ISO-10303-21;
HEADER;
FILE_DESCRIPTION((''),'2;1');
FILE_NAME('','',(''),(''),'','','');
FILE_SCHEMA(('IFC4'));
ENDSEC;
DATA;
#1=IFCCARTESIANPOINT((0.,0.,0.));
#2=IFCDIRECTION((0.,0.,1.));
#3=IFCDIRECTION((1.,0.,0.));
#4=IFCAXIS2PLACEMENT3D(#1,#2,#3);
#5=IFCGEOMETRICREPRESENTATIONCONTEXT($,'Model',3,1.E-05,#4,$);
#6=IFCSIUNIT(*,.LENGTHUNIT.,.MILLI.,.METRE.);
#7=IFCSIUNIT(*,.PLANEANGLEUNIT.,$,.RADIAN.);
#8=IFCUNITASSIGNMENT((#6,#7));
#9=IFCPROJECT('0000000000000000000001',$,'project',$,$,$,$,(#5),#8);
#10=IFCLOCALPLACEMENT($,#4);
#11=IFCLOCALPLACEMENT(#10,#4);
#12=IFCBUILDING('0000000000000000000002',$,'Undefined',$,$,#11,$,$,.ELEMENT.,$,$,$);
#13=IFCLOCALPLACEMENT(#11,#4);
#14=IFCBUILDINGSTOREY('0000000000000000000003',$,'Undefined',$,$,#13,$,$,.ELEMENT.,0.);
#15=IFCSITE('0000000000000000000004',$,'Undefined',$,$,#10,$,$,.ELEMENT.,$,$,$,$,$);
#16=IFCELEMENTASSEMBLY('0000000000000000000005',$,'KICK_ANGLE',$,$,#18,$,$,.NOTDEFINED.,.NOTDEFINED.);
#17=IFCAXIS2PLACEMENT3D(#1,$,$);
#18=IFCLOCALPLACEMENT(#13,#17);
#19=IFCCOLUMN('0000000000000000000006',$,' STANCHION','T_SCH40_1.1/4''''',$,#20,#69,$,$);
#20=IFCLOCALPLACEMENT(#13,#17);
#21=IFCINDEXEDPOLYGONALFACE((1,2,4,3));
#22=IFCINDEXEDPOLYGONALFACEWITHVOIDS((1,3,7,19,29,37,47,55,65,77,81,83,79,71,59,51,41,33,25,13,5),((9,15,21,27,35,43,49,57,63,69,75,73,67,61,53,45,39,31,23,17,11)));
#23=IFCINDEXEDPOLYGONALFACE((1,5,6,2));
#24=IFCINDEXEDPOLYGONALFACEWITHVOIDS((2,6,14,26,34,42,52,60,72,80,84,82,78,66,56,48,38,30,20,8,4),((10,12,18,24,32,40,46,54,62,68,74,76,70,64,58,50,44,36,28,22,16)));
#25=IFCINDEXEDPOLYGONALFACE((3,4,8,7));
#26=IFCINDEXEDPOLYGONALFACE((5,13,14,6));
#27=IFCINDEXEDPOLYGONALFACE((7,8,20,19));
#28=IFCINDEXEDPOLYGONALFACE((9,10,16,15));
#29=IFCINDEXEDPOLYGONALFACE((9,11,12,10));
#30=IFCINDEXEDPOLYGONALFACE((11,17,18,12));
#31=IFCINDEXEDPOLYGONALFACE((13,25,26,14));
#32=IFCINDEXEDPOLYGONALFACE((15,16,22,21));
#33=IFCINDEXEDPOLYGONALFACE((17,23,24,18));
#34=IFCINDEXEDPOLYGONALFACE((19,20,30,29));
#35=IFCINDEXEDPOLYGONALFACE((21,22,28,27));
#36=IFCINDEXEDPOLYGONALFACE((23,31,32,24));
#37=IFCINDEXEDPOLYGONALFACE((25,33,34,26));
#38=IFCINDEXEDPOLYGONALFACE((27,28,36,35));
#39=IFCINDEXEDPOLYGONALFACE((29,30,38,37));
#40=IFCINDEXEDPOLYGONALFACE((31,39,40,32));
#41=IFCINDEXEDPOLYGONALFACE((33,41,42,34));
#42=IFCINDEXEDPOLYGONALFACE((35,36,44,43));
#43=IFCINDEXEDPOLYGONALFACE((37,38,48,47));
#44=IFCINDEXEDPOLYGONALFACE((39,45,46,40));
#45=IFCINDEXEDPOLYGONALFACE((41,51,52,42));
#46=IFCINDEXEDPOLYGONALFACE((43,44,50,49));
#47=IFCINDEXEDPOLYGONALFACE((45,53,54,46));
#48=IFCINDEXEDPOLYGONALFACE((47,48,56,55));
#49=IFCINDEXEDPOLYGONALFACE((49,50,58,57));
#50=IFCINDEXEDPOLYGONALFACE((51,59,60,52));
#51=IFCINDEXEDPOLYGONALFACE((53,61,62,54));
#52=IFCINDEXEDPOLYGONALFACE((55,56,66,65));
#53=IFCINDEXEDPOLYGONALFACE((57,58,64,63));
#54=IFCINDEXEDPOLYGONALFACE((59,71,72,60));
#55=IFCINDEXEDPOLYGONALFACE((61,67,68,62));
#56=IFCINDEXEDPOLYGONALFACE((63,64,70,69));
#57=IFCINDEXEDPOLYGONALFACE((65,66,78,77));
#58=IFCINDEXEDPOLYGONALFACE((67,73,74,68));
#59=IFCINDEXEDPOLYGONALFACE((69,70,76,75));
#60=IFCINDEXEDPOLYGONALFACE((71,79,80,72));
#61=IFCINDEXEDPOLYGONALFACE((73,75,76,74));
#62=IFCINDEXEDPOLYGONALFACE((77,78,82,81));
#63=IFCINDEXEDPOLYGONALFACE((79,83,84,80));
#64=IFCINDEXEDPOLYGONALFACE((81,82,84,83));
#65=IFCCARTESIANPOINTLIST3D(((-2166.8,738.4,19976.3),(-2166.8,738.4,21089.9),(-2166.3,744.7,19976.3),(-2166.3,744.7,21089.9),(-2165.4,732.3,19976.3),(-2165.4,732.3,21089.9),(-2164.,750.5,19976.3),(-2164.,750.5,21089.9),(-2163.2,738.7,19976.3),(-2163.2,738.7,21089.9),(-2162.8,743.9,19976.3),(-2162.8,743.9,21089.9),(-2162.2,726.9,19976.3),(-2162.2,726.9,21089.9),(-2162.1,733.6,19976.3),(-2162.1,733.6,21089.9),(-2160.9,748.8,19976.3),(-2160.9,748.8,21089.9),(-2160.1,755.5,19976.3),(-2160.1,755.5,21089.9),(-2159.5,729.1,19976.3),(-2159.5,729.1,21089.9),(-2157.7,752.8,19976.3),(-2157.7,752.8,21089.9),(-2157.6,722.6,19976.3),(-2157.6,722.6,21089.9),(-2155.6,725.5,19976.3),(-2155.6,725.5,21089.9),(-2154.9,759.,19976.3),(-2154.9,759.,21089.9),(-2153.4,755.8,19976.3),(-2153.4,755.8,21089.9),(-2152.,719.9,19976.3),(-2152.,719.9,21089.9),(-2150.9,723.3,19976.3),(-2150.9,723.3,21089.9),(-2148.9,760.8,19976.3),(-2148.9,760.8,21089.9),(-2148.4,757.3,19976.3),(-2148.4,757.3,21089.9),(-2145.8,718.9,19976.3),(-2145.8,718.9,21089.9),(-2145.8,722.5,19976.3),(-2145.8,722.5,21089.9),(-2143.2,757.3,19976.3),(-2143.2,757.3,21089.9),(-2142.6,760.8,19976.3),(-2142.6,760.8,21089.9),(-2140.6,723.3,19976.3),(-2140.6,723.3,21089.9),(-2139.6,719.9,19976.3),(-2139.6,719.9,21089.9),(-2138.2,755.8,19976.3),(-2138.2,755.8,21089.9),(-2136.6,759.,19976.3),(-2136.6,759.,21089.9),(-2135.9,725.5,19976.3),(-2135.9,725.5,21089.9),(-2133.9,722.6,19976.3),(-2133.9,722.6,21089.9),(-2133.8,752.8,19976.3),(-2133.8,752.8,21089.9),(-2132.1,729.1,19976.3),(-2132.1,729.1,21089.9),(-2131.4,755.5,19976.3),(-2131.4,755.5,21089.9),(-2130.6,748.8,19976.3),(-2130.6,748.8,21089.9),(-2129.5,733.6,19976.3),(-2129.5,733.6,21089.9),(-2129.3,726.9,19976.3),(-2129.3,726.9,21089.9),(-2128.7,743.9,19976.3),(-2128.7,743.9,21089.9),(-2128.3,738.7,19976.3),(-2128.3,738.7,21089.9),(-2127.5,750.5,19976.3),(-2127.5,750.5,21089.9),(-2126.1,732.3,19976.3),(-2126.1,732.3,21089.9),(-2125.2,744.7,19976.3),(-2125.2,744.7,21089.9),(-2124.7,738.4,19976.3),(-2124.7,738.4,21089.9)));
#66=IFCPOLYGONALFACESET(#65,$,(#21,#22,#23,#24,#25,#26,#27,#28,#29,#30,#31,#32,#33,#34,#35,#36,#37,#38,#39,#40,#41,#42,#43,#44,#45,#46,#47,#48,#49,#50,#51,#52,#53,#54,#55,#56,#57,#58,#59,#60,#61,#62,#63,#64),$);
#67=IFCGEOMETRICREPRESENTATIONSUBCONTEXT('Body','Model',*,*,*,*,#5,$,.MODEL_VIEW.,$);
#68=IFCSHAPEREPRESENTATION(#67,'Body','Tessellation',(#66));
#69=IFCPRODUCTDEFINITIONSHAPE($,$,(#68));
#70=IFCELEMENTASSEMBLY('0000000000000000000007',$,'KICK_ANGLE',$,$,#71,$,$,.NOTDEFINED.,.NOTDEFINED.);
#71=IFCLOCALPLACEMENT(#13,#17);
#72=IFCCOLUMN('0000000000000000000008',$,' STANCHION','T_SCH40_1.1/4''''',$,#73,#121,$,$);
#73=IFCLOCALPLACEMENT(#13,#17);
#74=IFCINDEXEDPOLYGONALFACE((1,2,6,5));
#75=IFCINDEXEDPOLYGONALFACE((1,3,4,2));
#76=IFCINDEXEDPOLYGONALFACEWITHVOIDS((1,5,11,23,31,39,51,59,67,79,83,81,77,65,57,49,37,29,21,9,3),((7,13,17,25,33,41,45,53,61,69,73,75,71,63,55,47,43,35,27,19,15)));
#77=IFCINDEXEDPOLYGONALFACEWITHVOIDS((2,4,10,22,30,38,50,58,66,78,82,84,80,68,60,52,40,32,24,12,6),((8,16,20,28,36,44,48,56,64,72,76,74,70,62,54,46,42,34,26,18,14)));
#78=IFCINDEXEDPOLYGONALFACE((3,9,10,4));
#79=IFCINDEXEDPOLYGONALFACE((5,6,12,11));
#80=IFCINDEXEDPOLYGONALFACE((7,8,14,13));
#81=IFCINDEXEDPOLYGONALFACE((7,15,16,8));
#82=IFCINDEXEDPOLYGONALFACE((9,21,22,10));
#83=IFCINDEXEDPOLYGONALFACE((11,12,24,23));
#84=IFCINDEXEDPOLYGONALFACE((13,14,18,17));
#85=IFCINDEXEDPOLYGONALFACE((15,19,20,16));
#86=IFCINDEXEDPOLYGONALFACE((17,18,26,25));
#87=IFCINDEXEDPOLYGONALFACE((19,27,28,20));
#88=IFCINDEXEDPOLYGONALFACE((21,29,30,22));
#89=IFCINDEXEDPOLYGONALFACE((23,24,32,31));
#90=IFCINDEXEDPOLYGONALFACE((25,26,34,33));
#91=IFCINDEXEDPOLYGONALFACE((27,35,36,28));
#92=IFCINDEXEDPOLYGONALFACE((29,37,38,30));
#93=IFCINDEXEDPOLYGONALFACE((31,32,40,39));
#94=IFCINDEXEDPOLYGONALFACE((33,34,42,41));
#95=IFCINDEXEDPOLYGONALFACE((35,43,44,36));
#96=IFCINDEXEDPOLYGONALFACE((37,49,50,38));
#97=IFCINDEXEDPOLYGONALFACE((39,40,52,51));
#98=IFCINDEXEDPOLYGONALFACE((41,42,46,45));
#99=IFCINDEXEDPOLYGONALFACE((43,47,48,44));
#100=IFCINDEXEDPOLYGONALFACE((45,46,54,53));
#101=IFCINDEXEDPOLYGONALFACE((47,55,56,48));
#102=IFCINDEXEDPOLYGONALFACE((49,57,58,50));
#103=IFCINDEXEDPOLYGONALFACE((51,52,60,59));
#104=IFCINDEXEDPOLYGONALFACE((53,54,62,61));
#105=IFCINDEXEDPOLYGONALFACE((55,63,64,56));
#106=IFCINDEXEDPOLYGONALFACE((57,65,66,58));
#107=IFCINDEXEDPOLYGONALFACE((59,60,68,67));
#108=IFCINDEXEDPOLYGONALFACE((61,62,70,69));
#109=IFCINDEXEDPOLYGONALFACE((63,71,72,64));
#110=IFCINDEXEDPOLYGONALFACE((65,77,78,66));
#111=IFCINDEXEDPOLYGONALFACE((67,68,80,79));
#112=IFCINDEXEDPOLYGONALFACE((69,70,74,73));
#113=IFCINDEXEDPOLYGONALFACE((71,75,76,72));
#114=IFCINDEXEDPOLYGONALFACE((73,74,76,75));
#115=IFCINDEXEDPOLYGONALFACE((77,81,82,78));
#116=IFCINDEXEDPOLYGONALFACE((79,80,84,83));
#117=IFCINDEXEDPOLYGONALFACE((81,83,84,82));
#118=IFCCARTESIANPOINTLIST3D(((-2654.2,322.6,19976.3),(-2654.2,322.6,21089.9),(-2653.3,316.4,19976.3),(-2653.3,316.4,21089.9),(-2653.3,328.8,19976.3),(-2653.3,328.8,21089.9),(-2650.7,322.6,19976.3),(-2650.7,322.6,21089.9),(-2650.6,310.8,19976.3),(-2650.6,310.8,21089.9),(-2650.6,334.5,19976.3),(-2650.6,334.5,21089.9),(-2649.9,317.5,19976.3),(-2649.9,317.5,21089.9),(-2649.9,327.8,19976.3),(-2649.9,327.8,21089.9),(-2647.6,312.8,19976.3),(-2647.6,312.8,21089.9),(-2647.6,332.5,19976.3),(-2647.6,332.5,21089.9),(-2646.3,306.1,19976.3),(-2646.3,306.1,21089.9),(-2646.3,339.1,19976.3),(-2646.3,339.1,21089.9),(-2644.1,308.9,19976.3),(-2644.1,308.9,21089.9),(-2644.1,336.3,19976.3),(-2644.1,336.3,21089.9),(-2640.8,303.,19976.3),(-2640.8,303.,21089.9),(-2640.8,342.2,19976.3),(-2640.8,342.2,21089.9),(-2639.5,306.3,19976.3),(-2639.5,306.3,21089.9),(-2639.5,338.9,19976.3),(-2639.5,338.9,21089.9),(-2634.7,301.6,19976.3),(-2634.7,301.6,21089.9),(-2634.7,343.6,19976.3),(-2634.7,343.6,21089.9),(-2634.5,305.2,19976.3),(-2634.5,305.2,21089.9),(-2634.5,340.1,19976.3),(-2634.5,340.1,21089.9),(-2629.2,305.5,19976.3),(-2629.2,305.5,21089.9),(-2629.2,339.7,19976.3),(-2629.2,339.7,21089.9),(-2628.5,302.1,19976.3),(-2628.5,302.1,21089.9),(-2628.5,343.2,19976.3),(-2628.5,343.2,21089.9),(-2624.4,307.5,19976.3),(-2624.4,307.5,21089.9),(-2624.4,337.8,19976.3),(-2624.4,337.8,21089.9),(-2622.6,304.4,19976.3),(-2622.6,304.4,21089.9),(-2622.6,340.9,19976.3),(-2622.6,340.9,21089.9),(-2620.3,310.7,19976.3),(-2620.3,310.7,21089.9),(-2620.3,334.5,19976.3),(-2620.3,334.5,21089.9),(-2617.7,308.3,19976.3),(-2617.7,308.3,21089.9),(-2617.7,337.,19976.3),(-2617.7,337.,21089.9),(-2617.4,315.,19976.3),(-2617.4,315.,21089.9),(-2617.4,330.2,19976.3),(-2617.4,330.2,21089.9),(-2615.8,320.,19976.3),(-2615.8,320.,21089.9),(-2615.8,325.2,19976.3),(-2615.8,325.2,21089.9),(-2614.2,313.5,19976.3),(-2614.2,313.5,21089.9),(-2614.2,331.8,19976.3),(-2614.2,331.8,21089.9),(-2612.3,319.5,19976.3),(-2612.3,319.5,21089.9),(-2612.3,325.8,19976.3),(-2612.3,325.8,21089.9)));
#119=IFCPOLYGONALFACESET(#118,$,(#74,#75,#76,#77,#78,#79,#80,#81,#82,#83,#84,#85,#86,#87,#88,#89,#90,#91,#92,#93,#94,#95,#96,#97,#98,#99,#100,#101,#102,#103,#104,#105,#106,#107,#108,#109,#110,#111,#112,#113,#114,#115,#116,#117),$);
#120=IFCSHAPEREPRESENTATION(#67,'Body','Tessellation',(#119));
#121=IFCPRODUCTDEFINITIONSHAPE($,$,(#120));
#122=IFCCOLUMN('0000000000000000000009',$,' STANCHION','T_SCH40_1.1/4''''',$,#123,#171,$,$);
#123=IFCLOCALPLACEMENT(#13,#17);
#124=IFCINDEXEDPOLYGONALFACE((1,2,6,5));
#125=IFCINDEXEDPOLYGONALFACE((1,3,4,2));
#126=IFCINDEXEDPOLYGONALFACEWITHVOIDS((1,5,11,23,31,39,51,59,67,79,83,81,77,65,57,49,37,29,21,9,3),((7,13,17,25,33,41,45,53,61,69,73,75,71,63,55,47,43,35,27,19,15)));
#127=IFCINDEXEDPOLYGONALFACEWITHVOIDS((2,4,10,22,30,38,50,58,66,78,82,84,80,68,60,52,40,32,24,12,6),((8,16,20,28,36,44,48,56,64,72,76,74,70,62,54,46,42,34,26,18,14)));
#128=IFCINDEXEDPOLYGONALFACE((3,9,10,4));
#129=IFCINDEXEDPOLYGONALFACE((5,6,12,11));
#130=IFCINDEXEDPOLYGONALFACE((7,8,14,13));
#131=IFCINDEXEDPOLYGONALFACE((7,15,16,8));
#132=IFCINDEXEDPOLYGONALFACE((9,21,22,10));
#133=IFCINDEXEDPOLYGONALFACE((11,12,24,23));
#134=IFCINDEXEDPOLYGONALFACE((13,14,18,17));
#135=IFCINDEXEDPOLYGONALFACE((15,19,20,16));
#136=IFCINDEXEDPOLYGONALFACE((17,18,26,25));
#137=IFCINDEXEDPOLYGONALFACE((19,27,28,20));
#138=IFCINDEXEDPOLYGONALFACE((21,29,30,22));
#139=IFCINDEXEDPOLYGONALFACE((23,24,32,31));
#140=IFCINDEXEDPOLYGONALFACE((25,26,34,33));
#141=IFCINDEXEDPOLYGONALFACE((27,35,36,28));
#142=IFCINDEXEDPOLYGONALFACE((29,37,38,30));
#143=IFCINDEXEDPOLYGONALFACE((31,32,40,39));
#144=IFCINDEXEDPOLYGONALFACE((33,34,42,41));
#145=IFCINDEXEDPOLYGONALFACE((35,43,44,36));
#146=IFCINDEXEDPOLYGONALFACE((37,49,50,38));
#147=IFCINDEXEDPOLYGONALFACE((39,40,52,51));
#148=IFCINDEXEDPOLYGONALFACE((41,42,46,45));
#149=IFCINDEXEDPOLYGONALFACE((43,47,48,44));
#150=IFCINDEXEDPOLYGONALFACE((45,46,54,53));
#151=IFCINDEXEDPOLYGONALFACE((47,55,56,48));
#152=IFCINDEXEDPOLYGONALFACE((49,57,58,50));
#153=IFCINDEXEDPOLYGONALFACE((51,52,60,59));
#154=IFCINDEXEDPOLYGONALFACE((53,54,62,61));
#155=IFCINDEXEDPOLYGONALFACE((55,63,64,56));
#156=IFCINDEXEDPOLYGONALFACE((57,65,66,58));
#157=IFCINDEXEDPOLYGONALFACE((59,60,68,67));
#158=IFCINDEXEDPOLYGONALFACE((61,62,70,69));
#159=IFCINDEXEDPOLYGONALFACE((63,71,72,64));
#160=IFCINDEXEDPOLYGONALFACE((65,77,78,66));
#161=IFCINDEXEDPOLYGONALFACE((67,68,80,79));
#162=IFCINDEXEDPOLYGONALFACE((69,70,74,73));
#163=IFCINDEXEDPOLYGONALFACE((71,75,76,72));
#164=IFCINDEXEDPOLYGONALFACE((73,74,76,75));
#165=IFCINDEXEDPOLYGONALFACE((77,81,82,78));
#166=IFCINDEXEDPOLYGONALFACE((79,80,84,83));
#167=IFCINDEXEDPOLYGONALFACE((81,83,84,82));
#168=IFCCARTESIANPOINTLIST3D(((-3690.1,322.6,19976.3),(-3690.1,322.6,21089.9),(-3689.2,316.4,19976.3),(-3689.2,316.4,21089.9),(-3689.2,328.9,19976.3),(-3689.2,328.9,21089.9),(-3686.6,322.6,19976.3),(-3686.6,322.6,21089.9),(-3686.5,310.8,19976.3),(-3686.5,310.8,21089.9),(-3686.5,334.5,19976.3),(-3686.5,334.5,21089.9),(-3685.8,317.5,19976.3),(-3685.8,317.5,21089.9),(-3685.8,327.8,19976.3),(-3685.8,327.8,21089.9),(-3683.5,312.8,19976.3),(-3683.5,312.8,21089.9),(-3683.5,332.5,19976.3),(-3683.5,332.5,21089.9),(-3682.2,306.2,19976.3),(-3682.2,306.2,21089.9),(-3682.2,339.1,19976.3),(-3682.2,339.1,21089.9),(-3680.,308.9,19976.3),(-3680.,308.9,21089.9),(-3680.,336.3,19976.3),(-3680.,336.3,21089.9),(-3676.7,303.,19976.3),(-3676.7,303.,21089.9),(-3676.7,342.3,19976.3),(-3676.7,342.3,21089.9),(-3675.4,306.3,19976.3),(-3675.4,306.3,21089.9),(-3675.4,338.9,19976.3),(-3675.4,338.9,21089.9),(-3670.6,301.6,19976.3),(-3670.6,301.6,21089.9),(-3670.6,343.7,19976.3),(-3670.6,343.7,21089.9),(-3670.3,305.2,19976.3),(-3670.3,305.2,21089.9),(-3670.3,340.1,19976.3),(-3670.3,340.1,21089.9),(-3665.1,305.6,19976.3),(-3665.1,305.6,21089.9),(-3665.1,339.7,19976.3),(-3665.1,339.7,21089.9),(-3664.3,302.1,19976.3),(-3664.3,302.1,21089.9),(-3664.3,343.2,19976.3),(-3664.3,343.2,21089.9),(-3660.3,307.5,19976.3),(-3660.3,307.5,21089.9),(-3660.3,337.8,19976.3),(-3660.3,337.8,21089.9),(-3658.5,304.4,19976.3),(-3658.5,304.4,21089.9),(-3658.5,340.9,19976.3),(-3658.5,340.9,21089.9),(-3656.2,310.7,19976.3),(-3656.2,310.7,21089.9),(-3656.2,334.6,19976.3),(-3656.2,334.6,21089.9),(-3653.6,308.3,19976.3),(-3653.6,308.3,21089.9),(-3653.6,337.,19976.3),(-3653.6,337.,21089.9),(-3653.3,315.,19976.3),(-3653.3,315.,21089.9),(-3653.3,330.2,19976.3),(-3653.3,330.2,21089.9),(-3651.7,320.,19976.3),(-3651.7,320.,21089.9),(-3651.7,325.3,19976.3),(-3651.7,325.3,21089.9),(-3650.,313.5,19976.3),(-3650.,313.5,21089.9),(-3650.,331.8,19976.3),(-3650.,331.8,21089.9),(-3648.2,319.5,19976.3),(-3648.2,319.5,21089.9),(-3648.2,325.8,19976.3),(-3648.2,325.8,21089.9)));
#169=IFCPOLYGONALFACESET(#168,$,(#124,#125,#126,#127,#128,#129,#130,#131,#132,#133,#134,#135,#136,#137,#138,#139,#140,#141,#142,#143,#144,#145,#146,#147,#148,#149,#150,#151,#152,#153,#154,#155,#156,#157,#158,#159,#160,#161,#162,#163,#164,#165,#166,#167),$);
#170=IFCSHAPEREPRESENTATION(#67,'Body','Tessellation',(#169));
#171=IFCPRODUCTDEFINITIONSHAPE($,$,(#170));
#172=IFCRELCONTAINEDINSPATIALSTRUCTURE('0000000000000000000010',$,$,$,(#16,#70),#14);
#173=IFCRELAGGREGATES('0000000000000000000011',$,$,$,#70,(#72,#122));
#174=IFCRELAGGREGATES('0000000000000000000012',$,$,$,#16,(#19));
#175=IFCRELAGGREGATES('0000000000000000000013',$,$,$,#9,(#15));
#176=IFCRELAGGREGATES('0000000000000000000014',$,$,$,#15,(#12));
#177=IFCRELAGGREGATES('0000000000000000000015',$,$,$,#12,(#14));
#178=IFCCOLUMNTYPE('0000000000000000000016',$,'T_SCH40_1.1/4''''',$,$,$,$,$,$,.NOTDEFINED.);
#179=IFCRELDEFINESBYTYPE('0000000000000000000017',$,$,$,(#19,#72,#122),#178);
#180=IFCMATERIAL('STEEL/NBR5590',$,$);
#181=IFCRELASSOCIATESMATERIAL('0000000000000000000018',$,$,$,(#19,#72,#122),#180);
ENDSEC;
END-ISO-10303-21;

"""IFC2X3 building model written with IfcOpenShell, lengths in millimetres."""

from ifc_helpers import new_model, si_unit, frame, origin_with_axes, origin_2d_with_axis, place, context, subcontext, project, spatial, hollow_circle, extrude, material, type_object, element, aggregate, save


model = new_model("IFC2X3")

# Units and contexts
model_context = context("Model", 3, precision=1e-05, world=origin_with_axes())
body_context = subcontext(model_context, "Body", "Model", "MODEL_VIEW")
ifc_project = project(units=[si_unit("LENGTHUNIT", "METRE", prefix="MILLI"), si_unit("PLANEANGLEUNIT", "RADIAN")], contexts=[model_context])

# Site, building, storey
site_placement = place(None, origin_with_axes())
site = spatial("IfcSite", under=ifc_project, at=site_placement, Name="Undefined", CompositionType="ELEMENT")
building_placement = place(site_placement, origin_with_axes())
building = spatial("IfcBuilding", under=site, at=building_placement, Name="Undefined", CompositionType="ELEMENT")
storey_placement = place(building_placement, origin_with_axes())
storey = spatial("IfcBuildingStorey", under=building, at=storey_placement, Name="Undefined", CompositionType="ELEMENT", Elevation=0.0)

# Element assemblies, columns
assembly_1_placement = place(storey_placement, origin_with_axes())
assembly_1 = element("IfcElementAssembly", 1, at=assembly_1_placement, inside=storey, Name="KICK_ANGLE", AssemblyPlace="NOTDEFINED", PredefinedType="NOTDEFINED")
ifc_material_1 = material(Name="STEEL/NBR5590")
column_type_1 = type_object("IfcColumnType", Name="T_SCH40_1.1/4''", PredefinedType="NOTDEFINED")
column_1_placement = place(assembly_1_placement, frame((-2145.8, 740.0, 19976.3), z_axis=(0.0, 0.0, 1.0), x_axis=(-1.0, 0.0, 0.0)))
column_1 = element("IfcColumn", 2, at=column_1_placement, type_object=column_type_1, material=ifc_material_1, Name=" STANCHION", Description="T_SCH40_1.1/4''", context=body_context, shape_type="SweptSolid", body=[
    extrude(hollow_circle(Radius=21.1, WallThickness=3.6, at=origin_2d_with_axis()), frame((0.0, 0.0, 1113.6), z_axis=(0.0, 0.0, -1.0), x_axis=(0.0, 1.0, 0.0)), (0.0, 0.0, 1.0), 1113.6),
])
assembly_2_placement = place(storey_placement, origin_with_axes())
assembly_2 = element("IfcElementAssembly", 3, at=assembly_2_placement, inside=storey, Name="KICK_ANGLE", AssemblyPlace="NOTDEFINED", PredefinedType="NOTDEFINED")
column_2_placement = place(assembly_2_placement, frame((-2633.1, 322.6, 19976.3), z_axis=(0.0, 0.0, 1.0), x_axis=(0.000015, 1.0, 0.0)))
column_2 = element("IfcColumn", 4, at=column_2_placement, type_object=column_type_1, material=ifc_material_1, Name=" STANCHION", Description="T_SCH40_1.1/4''", context=body_context, shape_type="SweptSolid", body=[
    extrude(hollow_circle(Radius=21.1, WallThickness=3.6, at=origin_2d_with_axis()), frame((0.0, 0.0, 1113.6), z_axis=(0.0, 0.0, -1.0), x_axis=(0.0, 1.0, 0.0)), (0.0, 0.0, 1.0), 1113.6),
])
column_3_placement = place(assembly_2_placement, frame((-3669.0, 322.6, 19976.3), z_axis=(0.0, 0.0, 1.0), x_axis=(0.000015, 1.0, 0.0)))
column_3 = element("IfcColumn", 5, at=column_3_placement, type_object=column_type_1, material=ifc_material_1, Name=" STANCHION", Description="T_SCH40_1.1/4''", context=body_context, shape_type="SweptSolid", body=[
    extrude(hollow_circle(Radius=21.1, WallThickness=3.6, at=origin_2d_with_axis()), frame((0.0, 0.0, 1113.6), z_axis=(0.0, 0.0, -1.0), x_axis=(0.0, 1.0, 0.0)), (0.0, 0.0, 1.0), 1113.6),
])

aggregate(assembly_2, [column_2, column_3])
aggregate(assembly_1, [column_1])

save(model, "model.ifc")
